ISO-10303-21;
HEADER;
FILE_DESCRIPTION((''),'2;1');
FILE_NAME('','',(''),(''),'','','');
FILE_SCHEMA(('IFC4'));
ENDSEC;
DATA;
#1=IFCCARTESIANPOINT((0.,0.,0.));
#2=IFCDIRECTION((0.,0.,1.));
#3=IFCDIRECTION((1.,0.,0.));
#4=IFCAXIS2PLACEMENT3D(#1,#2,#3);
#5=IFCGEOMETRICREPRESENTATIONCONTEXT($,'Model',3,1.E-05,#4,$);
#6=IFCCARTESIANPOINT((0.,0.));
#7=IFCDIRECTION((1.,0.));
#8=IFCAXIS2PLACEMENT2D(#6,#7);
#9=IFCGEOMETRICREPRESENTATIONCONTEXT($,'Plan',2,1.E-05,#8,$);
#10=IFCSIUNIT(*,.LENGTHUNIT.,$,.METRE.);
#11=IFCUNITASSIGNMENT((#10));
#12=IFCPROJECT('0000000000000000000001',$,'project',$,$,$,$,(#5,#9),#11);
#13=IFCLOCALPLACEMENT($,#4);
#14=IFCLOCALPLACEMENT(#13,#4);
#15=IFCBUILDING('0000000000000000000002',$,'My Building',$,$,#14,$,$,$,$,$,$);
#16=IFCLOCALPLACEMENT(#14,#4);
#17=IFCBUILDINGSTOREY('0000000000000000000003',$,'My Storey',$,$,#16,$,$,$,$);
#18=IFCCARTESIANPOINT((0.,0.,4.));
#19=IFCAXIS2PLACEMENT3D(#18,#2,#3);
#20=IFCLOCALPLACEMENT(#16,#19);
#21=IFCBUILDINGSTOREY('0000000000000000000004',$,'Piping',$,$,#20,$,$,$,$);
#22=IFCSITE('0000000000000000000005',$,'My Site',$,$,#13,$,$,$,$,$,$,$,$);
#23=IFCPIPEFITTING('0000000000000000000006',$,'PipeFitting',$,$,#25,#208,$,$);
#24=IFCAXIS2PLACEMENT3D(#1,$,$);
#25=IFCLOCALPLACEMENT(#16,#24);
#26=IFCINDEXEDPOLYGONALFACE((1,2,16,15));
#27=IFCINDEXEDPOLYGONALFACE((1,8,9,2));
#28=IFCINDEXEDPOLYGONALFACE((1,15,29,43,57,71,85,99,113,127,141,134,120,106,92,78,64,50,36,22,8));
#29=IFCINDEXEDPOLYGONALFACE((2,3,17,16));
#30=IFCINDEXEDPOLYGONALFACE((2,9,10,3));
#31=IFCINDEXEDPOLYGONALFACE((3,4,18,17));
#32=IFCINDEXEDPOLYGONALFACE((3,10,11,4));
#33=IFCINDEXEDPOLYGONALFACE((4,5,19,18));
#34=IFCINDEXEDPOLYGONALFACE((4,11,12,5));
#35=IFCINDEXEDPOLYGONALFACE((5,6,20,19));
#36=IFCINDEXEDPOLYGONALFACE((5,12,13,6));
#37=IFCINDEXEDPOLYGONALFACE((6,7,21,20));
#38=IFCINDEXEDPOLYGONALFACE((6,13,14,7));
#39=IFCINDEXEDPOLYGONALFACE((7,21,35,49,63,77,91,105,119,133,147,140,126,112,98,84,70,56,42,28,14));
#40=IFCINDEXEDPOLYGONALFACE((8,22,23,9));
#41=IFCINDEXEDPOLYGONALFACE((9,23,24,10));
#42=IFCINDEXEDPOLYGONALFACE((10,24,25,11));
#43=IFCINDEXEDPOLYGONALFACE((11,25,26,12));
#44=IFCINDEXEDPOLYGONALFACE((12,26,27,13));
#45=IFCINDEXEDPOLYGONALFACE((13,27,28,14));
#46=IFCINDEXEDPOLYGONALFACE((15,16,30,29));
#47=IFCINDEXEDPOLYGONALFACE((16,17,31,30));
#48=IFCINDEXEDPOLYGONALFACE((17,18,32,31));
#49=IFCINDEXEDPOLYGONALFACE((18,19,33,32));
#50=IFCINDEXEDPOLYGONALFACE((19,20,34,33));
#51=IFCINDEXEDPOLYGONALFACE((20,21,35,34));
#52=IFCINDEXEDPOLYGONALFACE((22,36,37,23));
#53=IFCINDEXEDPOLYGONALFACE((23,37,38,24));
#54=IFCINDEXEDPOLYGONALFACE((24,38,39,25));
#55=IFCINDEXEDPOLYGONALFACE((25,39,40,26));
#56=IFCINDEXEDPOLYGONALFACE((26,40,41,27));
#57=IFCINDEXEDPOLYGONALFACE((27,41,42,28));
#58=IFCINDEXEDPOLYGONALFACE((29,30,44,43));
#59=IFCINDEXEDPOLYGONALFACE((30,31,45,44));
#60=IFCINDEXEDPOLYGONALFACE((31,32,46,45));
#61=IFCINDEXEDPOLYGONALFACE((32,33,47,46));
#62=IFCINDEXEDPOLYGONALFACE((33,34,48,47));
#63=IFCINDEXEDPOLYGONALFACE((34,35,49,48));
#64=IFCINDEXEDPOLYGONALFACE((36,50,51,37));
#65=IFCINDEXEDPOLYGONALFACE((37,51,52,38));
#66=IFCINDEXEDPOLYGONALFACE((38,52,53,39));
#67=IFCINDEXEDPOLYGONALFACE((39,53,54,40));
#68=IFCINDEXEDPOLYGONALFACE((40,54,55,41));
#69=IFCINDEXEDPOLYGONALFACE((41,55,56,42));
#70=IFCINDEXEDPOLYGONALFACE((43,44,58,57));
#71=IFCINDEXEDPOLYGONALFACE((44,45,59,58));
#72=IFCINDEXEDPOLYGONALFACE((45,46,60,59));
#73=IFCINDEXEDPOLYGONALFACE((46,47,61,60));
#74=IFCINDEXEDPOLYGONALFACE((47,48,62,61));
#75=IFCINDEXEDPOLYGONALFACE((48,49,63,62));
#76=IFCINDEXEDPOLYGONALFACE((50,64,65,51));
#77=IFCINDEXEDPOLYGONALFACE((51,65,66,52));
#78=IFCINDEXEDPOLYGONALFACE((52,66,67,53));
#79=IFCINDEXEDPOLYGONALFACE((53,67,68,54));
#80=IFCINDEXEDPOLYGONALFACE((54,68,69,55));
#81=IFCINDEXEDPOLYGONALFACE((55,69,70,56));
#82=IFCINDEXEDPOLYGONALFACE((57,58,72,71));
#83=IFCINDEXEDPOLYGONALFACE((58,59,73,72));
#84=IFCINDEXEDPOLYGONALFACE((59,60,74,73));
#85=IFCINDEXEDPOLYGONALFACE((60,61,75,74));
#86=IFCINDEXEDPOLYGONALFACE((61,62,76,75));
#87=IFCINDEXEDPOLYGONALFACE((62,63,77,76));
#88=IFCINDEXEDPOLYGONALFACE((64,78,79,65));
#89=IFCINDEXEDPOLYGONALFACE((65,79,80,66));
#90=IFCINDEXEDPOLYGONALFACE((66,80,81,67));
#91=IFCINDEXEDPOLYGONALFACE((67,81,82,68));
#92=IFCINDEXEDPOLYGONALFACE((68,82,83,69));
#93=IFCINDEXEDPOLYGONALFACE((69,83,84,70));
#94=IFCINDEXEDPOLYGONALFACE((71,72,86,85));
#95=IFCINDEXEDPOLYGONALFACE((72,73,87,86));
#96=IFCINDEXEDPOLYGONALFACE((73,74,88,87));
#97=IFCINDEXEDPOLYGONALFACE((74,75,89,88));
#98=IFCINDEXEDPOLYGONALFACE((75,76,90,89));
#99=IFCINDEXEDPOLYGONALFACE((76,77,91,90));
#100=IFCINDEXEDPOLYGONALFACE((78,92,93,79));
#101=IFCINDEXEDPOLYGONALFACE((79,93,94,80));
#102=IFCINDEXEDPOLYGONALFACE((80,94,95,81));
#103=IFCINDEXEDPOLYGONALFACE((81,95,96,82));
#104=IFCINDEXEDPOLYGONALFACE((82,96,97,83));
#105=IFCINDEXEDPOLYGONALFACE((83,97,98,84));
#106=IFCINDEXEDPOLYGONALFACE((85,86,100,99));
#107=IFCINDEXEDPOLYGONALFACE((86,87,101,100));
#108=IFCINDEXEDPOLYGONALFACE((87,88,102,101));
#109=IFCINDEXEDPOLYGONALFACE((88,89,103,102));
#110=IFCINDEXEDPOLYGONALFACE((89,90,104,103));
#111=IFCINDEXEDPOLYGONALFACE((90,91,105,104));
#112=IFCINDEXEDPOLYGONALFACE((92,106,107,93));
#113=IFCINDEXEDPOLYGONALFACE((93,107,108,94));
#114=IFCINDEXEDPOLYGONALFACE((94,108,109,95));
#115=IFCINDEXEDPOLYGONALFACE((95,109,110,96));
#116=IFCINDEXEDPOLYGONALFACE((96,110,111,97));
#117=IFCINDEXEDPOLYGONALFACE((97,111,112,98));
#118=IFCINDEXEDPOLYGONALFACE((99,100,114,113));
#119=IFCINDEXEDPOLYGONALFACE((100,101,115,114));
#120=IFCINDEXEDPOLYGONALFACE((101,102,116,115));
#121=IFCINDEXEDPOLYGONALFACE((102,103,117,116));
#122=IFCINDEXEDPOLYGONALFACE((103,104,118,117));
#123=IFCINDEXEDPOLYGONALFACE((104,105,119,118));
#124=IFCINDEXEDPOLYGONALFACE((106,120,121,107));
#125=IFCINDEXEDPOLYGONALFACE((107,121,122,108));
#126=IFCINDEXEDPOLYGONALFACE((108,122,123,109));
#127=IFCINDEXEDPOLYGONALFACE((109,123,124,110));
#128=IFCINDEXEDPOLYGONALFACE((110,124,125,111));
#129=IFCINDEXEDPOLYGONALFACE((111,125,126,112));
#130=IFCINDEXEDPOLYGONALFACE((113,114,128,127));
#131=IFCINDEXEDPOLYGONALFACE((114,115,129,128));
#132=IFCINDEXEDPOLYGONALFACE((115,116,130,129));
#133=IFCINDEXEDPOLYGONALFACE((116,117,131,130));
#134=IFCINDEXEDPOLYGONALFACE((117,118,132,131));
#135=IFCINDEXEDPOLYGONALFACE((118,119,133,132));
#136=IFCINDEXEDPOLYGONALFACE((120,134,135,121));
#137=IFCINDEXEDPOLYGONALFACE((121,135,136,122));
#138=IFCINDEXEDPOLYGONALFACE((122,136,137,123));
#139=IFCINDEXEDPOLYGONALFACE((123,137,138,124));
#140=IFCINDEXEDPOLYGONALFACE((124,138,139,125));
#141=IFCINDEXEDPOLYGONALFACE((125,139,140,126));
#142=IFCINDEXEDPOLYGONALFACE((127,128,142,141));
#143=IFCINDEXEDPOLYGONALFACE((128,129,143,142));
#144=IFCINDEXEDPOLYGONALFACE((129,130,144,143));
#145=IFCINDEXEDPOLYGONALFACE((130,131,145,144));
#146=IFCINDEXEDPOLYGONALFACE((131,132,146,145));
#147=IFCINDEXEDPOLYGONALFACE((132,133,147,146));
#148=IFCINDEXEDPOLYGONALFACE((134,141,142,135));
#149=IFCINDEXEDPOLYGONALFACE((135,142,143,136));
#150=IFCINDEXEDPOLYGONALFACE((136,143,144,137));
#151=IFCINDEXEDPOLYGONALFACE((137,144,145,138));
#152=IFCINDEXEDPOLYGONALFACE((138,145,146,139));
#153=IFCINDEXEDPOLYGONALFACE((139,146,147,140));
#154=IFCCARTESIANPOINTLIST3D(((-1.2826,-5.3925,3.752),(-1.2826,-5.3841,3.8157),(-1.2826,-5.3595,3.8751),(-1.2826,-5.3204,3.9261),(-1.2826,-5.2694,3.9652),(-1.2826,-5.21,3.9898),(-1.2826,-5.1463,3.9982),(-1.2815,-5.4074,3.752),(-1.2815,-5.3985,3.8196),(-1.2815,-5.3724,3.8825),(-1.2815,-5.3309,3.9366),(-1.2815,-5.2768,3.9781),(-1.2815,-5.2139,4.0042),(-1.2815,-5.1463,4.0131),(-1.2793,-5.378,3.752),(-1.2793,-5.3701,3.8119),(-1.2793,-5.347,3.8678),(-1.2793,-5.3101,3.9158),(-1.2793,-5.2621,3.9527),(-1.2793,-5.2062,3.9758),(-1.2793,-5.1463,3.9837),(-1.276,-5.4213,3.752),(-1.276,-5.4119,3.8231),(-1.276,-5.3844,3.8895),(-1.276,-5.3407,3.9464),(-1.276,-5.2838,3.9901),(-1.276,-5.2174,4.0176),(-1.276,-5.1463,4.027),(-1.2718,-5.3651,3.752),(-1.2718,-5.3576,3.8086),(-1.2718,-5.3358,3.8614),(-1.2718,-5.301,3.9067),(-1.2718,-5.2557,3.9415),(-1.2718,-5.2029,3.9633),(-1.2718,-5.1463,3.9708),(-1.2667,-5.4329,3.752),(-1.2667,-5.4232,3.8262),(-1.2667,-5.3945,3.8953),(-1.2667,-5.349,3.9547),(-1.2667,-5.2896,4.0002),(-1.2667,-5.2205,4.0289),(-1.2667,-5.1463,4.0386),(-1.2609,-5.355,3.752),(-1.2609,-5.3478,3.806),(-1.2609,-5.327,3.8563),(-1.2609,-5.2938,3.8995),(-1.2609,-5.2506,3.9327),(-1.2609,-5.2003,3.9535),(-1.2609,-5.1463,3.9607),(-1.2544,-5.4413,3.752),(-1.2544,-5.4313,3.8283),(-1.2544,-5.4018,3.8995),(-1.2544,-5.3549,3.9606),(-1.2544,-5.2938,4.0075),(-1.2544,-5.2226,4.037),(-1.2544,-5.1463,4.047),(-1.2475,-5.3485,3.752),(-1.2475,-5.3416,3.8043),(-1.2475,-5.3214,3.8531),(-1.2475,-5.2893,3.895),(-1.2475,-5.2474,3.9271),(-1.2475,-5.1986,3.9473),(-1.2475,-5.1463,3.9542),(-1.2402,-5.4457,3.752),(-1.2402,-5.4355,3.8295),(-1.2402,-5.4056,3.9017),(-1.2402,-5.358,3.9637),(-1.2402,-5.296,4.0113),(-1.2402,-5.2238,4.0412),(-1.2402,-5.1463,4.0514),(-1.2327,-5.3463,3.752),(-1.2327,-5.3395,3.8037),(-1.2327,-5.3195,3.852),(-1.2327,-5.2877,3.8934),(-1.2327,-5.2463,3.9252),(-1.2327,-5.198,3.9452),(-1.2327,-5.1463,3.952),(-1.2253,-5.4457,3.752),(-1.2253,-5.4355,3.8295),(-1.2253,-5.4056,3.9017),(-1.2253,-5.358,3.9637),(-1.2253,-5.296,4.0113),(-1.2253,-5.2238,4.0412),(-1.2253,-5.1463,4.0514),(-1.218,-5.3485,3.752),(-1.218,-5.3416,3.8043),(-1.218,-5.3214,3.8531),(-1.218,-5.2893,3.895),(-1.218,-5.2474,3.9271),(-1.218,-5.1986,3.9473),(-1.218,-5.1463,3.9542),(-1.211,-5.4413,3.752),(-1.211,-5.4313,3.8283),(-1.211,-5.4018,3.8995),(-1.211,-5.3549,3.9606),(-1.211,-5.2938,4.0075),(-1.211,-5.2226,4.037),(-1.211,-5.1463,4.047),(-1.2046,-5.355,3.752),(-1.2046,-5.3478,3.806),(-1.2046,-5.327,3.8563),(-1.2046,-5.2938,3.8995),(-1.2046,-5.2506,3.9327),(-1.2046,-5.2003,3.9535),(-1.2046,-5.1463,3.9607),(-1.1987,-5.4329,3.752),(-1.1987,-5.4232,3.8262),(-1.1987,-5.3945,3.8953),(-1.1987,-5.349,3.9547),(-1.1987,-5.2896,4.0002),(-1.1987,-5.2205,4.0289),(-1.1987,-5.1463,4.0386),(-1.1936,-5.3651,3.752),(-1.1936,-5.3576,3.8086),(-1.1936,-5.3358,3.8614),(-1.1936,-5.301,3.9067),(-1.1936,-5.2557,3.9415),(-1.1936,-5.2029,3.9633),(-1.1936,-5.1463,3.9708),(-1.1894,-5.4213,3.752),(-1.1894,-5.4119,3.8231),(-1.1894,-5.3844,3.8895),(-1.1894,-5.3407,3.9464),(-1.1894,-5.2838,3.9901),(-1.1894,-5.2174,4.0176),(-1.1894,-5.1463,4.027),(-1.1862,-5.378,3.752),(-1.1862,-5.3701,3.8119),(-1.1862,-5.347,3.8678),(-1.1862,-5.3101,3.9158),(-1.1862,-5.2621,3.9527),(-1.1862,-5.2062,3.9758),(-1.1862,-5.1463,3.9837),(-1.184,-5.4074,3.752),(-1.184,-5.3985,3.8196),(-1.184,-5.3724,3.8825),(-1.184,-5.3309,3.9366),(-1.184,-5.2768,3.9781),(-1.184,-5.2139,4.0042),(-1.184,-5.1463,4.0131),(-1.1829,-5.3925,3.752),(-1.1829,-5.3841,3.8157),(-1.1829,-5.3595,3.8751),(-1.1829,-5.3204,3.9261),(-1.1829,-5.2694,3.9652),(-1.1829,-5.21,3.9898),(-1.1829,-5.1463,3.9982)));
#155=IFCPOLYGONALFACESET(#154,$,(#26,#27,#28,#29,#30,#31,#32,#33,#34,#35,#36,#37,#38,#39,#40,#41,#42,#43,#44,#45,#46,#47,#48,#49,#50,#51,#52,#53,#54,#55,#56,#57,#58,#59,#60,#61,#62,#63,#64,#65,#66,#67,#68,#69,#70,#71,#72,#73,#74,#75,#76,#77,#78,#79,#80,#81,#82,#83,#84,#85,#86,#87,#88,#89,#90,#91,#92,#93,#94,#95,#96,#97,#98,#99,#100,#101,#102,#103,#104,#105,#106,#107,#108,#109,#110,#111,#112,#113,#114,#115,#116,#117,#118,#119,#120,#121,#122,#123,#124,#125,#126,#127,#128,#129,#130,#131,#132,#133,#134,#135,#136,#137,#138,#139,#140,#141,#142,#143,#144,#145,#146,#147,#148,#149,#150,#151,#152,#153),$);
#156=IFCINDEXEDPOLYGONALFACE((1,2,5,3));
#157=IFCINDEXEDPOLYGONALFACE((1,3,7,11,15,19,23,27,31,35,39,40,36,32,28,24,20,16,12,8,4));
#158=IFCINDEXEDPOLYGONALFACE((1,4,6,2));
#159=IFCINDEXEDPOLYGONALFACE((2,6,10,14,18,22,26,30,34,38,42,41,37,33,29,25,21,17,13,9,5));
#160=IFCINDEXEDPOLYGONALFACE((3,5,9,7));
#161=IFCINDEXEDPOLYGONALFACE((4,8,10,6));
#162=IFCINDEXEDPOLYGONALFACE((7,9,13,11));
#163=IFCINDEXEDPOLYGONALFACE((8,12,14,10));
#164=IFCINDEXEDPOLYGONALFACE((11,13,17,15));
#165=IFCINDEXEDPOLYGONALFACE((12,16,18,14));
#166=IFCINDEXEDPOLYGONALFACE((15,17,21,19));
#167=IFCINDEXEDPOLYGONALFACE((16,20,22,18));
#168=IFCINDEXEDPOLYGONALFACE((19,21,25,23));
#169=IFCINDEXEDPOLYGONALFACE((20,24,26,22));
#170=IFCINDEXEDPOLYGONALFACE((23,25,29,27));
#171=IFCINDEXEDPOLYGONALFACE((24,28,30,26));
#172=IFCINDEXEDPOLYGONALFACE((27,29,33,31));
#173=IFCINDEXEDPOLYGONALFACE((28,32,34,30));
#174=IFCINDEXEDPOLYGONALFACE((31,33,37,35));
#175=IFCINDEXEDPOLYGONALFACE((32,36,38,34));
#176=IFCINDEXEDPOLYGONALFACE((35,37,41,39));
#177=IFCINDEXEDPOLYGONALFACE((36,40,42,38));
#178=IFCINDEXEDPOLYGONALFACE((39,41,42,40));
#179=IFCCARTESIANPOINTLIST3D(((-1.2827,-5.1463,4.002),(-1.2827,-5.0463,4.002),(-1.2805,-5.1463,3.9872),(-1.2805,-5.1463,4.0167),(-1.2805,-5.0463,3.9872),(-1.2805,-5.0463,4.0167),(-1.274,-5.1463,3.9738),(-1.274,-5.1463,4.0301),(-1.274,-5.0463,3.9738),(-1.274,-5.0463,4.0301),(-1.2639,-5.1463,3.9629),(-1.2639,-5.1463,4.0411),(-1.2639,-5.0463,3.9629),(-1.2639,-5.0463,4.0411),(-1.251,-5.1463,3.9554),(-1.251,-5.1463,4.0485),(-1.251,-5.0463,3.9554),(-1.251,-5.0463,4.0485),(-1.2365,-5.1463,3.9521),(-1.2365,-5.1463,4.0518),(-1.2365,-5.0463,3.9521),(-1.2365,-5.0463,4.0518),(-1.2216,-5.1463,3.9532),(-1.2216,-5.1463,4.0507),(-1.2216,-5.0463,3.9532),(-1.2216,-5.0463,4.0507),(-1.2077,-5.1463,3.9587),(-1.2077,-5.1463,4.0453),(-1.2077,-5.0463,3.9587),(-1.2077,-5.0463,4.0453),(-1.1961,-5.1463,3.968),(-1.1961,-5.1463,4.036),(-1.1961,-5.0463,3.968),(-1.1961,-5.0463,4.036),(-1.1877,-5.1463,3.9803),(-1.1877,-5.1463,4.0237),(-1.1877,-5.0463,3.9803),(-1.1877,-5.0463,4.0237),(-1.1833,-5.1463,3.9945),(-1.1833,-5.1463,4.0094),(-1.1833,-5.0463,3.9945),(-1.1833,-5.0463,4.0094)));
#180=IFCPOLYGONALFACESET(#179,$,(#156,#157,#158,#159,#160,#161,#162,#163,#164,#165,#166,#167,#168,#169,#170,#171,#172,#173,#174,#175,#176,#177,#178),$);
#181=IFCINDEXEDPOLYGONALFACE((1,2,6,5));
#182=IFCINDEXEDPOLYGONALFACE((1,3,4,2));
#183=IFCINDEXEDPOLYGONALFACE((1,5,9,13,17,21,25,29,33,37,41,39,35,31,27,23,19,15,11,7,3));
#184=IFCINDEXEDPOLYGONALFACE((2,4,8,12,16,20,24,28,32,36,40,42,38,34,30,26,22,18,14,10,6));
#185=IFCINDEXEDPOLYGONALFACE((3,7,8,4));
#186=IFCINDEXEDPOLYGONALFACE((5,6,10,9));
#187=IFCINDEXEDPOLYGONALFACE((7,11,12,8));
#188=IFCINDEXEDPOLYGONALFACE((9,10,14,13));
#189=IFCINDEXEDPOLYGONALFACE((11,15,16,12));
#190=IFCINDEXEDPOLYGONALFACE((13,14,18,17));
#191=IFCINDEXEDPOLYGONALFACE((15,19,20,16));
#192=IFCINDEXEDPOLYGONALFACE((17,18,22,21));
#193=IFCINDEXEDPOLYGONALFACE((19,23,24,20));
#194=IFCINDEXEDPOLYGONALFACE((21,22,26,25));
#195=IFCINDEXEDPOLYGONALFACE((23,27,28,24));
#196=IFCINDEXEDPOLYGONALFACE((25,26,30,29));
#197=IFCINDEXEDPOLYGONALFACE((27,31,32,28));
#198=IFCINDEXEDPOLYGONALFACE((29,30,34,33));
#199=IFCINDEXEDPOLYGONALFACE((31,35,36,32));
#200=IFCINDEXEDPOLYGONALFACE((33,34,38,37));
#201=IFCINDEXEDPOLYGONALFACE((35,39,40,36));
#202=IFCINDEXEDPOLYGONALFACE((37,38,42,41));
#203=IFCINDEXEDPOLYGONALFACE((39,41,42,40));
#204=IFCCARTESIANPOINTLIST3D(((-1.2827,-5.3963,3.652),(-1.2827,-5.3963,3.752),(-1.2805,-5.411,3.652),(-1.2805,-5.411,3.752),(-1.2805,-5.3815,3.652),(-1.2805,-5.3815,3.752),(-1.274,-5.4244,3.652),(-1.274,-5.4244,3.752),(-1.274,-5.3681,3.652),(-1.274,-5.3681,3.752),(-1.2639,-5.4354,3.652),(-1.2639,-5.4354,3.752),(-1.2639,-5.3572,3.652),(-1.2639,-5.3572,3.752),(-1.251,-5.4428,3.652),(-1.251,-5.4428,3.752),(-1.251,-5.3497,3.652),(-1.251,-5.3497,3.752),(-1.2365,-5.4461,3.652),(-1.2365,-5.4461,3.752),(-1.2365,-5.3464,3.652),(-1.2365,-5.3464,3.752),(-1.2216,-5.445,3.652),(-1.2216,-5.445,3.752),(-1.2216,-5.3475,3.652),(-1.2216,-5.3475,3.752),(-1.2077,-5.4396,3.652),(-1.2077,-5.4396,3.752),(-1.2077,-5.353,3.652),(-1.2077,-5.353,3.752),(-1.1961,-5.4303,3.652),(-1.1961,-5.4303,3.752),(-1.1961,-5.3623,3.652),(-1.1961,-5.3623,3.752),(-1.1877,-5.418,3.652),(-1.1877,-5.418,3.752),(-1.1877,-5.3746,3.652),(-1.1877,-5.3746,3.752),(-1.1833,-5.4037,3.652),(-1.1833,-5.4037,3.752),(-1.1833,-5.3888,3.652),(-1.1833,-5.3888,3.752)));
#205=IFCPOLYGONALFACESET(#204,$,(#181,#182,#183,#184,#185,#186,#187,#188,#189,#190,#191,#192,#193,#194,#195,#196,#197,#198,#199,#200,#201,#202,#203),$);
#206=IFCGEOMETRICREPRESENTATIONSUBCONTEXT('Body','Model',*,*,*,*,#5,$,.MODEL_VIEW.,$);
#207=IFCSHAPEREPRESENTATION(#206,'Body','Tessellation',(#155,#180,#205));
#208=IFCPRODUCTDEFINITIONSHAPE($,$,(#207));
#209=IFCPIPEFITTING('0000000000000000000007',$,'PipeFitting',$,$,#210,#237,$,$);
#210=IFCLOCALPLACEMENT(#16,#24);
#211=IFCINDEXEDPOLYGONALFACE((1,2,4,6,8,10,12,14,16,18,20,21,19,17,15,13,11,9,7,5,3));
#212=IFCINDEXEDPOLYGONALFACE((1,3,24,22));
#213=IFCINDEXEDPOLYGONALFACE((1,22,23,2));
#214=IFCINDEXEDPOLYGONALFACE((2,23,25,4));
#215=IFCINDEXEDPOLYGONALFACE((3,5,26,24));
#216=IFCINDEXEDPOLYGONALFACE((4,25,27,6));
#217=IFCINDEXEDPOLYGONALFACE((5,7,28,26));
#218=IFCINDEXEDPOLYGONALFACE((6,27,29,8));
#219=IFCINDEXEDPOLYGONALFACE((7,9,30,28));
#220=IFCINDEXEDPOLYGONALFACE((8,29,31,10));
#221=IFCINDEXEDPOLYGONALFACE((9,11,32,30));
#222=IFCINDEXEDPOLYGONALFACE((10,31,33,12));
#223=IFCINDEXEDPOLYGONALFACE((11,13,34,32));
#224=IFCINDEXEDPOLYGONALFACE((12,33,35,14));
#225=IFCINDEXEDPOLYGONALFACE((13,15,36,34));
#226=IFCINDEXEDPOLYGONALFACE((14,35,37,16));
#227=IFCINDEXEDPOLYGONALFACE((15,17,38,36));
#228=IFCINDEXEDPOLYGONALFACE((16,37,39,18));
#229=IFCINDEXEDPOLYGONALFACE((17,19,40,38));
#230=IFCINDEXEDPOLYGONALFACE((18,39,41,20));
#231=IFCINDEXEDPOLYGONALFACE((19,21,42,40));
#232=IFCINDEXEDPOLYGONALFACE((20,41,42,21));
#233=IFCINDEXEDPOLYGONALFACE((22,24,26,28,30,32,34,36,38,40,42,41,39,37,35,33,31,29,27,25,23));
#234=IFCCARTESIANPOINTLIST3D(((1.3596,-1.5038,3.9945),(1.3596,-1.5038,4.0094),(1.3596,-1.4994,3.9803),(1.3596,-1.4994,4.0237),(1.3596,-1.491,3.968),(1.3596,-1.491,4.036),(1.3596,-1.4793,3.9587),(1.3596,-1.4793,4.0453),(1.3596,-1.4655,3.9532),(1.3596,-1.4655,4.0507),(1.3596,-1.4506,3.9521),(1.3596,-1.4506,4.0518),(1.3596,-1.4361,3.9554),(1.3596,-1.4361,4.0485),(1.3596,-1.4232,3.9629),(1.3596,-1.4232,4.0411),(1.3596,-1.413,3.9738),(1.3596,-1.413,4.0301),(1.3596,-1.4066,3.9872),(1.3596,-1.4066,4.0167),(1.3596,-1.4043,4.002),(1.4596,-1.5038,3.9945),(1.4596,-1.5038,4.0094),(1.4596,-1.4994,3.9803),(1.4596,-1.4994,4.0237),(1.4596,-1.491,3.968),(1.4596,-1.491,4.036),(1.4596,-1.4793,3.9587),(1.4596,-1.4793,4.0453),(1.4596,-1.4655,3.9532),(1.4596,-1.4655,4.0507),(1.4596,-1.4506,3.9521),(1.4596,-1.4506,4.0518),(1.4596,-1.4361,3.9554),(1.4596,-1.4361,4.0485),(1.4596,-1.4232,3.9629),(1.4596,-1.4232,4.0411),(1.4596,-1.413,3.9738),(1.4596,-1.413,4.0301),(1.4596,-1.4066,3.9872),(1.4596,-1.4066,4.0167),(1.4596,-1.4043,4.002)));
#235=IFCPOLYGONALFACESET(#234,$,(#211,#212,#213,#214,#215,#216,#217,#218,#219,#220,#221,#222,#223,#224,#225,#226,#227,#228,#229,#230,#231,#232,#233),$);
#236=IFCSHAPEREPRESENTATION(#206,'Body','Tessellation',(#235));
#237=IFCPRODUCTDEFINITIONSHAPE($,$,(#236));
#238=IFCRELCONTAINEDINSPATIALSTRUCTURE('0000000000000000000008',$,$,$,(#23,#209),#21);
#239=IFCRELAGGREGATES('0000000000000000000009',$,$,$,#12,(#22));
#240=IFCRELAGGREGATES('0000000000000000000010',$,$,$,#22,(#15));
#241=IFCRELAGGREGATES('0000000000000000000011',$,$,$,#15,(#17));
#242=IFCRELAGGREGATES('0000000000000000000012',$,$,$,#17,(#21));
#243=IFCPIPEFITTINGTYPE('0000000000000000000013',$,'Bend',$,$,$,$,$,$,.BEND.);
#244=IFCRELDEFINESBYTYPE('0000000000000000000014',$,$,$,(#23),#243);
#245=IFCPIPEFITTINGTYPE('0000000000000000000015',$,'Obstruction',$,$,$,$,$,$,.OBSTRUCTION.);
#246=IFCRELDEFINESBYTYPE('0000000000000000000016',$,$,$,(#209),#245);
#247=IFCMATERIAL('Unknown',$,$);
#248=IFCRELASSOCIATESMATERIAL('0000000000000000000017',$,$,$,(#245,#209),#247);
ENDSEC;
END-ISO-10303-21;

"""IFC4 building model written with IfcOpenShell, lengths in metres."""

from ifc_helpers import new_model, entity, si_unit, frame, origin_with_axes, origin_2d_with_axis, place, context, subcontext, project, spatial, circle, extrude, source, transform, mapped, material, material_profile, profile_set, profile_usage, type_object, type_shapes, element, save


model = new_model("IFC4")

# Units and contexts
model_context = context("Model", 3, precision=1e-05, world=origin_with_axes())
plan_context = context("Plan", 2, precision=1e-05, world=origin_2d_with_axis())
body_context = subcontext(model_context, "Body", "Model", "MODEL_VIEW")
ifc_project = project(units=[si_unit("LENGTHUNIT", "METRE")], contexts=[model_context, plan_context])

# Site, building, storeys
site_placement = place(None, origin_with_axes())
site = spatial("IfcSite", under=ifc_project, at=site_placement, Name="My Site")
building_placement = place(site_placement, origin_with_axes())
building = spatial("IfcBuilding", under=site, at=building_placement, Name="My Building")
storey_1_placement = place(building_placement, origin_with_axes())
storey_1 = spatial("IfcBuildingStorey", under=building, at=storey_1_placement, Name="My Storey")
storey_2_placement = place(storey_1_placement, frame((0.0, 0.0, 4.0), z_axis=(0.0, 0.0, 1.0), x_axis=(1.0, 0.0, 0.0)))
storey_2 = spatial("IfcBuildingStorey", under=storey_1, at=storey_2_placement, Name="Piping")

# Shared definitions
ifc_material = material(Name="Unknown")

# Shared definitions
pipe_fitting_type_1 = type_object("IfcPipeFittingType", Name="Bend", PredefinedType="BEND")
shared_shape = source(origin_with_axes(), body_context, "Body", "SolidModel", [
    entity("IfcSweptDiskSolid", entity("IfcIndexedPolyCurve", entity("IfcCartesianPointList3D", [[0.0, 0.0, -0.1], [0.0, -0.0732, -0.2768], [0.0, -0.25, -0.35]]), [entity("IfcArcIndex", [1, 2, 3])]), 0.05),
    extrude(circle(Radius=0.05), origin_with_axes(), (0.0, 0.0, -1.0), 0.1),
    extrude(circle(Radius=0.05), frame((0.0, -0.25, -0.35), z_axis=(0.0, -1.0, 0.0), x_axis=(1.0, 0.0, 0.0)), (0.0, 0.0, 1.0), 0.1),
])
type_shapes(pipe_fitting_type_1, [shared_shape])

# Pipe fittings
pipe_fitting_1_placement = place(storey_2_placement, frame((-1.2327, -5.0463, 0.002), z_axis=(0.0, 1.0, 0.000001), x_axis=(-1.0, 0.0, 0.0)))
element("IfcPipeFitting", 1, at=pipe_fitting_1_placement, inside=storey_2, type_object=pipe_fitting_type_1, Name="PipeFitting", context=body_context, shape_type="MappedRepresentation", body=[
    mapped(shared_shape, transform((0.0, 0.0, 0.0), x_axis=(1.0, 0.0, 0.0), y_axis=(0.0, 1.0, 0.0), z_axis=(0.0, 0.0, 1.0), scale=1.0)),
])
ifc_material_profile_1 = material_profile(ifc_material, circle(Radius=0.05))
ifc_profile_set_1 = profile_set([ifc_material_profile_1])
ifc_profile_usage_1 = profile_usage(ifc_profile_set_1, cardinal=5)
pipe_fitting_type_2 = type_object("IfcPipeFittingType", Name="Obstruction", PredefinedType="OBSTRUCTION", material=ifc_profile_set_1)
pipe_fitting_2_placement = place(storey_2_placement, frame((1.3596, -1.4543, 0.002), z_axis=(1.0, 0.0, 0.0), x_axis=(0.0, 1.0, 0.0)))
element("IfcPipeFitting", 2, at=pipe_fitting_2_placement, inside=storey_2, type_object=pipe_fitting_type_2, material=ifc_profile_usage_1, Name="PipeFitting", context=body_context, shape_type="SweptSolid", body=[
    extrude(circle(Radius=0.05), origin_with_axes(), (0.0, 0.0, 1.0), 0.1),
])

save(model, "model.ifc")
